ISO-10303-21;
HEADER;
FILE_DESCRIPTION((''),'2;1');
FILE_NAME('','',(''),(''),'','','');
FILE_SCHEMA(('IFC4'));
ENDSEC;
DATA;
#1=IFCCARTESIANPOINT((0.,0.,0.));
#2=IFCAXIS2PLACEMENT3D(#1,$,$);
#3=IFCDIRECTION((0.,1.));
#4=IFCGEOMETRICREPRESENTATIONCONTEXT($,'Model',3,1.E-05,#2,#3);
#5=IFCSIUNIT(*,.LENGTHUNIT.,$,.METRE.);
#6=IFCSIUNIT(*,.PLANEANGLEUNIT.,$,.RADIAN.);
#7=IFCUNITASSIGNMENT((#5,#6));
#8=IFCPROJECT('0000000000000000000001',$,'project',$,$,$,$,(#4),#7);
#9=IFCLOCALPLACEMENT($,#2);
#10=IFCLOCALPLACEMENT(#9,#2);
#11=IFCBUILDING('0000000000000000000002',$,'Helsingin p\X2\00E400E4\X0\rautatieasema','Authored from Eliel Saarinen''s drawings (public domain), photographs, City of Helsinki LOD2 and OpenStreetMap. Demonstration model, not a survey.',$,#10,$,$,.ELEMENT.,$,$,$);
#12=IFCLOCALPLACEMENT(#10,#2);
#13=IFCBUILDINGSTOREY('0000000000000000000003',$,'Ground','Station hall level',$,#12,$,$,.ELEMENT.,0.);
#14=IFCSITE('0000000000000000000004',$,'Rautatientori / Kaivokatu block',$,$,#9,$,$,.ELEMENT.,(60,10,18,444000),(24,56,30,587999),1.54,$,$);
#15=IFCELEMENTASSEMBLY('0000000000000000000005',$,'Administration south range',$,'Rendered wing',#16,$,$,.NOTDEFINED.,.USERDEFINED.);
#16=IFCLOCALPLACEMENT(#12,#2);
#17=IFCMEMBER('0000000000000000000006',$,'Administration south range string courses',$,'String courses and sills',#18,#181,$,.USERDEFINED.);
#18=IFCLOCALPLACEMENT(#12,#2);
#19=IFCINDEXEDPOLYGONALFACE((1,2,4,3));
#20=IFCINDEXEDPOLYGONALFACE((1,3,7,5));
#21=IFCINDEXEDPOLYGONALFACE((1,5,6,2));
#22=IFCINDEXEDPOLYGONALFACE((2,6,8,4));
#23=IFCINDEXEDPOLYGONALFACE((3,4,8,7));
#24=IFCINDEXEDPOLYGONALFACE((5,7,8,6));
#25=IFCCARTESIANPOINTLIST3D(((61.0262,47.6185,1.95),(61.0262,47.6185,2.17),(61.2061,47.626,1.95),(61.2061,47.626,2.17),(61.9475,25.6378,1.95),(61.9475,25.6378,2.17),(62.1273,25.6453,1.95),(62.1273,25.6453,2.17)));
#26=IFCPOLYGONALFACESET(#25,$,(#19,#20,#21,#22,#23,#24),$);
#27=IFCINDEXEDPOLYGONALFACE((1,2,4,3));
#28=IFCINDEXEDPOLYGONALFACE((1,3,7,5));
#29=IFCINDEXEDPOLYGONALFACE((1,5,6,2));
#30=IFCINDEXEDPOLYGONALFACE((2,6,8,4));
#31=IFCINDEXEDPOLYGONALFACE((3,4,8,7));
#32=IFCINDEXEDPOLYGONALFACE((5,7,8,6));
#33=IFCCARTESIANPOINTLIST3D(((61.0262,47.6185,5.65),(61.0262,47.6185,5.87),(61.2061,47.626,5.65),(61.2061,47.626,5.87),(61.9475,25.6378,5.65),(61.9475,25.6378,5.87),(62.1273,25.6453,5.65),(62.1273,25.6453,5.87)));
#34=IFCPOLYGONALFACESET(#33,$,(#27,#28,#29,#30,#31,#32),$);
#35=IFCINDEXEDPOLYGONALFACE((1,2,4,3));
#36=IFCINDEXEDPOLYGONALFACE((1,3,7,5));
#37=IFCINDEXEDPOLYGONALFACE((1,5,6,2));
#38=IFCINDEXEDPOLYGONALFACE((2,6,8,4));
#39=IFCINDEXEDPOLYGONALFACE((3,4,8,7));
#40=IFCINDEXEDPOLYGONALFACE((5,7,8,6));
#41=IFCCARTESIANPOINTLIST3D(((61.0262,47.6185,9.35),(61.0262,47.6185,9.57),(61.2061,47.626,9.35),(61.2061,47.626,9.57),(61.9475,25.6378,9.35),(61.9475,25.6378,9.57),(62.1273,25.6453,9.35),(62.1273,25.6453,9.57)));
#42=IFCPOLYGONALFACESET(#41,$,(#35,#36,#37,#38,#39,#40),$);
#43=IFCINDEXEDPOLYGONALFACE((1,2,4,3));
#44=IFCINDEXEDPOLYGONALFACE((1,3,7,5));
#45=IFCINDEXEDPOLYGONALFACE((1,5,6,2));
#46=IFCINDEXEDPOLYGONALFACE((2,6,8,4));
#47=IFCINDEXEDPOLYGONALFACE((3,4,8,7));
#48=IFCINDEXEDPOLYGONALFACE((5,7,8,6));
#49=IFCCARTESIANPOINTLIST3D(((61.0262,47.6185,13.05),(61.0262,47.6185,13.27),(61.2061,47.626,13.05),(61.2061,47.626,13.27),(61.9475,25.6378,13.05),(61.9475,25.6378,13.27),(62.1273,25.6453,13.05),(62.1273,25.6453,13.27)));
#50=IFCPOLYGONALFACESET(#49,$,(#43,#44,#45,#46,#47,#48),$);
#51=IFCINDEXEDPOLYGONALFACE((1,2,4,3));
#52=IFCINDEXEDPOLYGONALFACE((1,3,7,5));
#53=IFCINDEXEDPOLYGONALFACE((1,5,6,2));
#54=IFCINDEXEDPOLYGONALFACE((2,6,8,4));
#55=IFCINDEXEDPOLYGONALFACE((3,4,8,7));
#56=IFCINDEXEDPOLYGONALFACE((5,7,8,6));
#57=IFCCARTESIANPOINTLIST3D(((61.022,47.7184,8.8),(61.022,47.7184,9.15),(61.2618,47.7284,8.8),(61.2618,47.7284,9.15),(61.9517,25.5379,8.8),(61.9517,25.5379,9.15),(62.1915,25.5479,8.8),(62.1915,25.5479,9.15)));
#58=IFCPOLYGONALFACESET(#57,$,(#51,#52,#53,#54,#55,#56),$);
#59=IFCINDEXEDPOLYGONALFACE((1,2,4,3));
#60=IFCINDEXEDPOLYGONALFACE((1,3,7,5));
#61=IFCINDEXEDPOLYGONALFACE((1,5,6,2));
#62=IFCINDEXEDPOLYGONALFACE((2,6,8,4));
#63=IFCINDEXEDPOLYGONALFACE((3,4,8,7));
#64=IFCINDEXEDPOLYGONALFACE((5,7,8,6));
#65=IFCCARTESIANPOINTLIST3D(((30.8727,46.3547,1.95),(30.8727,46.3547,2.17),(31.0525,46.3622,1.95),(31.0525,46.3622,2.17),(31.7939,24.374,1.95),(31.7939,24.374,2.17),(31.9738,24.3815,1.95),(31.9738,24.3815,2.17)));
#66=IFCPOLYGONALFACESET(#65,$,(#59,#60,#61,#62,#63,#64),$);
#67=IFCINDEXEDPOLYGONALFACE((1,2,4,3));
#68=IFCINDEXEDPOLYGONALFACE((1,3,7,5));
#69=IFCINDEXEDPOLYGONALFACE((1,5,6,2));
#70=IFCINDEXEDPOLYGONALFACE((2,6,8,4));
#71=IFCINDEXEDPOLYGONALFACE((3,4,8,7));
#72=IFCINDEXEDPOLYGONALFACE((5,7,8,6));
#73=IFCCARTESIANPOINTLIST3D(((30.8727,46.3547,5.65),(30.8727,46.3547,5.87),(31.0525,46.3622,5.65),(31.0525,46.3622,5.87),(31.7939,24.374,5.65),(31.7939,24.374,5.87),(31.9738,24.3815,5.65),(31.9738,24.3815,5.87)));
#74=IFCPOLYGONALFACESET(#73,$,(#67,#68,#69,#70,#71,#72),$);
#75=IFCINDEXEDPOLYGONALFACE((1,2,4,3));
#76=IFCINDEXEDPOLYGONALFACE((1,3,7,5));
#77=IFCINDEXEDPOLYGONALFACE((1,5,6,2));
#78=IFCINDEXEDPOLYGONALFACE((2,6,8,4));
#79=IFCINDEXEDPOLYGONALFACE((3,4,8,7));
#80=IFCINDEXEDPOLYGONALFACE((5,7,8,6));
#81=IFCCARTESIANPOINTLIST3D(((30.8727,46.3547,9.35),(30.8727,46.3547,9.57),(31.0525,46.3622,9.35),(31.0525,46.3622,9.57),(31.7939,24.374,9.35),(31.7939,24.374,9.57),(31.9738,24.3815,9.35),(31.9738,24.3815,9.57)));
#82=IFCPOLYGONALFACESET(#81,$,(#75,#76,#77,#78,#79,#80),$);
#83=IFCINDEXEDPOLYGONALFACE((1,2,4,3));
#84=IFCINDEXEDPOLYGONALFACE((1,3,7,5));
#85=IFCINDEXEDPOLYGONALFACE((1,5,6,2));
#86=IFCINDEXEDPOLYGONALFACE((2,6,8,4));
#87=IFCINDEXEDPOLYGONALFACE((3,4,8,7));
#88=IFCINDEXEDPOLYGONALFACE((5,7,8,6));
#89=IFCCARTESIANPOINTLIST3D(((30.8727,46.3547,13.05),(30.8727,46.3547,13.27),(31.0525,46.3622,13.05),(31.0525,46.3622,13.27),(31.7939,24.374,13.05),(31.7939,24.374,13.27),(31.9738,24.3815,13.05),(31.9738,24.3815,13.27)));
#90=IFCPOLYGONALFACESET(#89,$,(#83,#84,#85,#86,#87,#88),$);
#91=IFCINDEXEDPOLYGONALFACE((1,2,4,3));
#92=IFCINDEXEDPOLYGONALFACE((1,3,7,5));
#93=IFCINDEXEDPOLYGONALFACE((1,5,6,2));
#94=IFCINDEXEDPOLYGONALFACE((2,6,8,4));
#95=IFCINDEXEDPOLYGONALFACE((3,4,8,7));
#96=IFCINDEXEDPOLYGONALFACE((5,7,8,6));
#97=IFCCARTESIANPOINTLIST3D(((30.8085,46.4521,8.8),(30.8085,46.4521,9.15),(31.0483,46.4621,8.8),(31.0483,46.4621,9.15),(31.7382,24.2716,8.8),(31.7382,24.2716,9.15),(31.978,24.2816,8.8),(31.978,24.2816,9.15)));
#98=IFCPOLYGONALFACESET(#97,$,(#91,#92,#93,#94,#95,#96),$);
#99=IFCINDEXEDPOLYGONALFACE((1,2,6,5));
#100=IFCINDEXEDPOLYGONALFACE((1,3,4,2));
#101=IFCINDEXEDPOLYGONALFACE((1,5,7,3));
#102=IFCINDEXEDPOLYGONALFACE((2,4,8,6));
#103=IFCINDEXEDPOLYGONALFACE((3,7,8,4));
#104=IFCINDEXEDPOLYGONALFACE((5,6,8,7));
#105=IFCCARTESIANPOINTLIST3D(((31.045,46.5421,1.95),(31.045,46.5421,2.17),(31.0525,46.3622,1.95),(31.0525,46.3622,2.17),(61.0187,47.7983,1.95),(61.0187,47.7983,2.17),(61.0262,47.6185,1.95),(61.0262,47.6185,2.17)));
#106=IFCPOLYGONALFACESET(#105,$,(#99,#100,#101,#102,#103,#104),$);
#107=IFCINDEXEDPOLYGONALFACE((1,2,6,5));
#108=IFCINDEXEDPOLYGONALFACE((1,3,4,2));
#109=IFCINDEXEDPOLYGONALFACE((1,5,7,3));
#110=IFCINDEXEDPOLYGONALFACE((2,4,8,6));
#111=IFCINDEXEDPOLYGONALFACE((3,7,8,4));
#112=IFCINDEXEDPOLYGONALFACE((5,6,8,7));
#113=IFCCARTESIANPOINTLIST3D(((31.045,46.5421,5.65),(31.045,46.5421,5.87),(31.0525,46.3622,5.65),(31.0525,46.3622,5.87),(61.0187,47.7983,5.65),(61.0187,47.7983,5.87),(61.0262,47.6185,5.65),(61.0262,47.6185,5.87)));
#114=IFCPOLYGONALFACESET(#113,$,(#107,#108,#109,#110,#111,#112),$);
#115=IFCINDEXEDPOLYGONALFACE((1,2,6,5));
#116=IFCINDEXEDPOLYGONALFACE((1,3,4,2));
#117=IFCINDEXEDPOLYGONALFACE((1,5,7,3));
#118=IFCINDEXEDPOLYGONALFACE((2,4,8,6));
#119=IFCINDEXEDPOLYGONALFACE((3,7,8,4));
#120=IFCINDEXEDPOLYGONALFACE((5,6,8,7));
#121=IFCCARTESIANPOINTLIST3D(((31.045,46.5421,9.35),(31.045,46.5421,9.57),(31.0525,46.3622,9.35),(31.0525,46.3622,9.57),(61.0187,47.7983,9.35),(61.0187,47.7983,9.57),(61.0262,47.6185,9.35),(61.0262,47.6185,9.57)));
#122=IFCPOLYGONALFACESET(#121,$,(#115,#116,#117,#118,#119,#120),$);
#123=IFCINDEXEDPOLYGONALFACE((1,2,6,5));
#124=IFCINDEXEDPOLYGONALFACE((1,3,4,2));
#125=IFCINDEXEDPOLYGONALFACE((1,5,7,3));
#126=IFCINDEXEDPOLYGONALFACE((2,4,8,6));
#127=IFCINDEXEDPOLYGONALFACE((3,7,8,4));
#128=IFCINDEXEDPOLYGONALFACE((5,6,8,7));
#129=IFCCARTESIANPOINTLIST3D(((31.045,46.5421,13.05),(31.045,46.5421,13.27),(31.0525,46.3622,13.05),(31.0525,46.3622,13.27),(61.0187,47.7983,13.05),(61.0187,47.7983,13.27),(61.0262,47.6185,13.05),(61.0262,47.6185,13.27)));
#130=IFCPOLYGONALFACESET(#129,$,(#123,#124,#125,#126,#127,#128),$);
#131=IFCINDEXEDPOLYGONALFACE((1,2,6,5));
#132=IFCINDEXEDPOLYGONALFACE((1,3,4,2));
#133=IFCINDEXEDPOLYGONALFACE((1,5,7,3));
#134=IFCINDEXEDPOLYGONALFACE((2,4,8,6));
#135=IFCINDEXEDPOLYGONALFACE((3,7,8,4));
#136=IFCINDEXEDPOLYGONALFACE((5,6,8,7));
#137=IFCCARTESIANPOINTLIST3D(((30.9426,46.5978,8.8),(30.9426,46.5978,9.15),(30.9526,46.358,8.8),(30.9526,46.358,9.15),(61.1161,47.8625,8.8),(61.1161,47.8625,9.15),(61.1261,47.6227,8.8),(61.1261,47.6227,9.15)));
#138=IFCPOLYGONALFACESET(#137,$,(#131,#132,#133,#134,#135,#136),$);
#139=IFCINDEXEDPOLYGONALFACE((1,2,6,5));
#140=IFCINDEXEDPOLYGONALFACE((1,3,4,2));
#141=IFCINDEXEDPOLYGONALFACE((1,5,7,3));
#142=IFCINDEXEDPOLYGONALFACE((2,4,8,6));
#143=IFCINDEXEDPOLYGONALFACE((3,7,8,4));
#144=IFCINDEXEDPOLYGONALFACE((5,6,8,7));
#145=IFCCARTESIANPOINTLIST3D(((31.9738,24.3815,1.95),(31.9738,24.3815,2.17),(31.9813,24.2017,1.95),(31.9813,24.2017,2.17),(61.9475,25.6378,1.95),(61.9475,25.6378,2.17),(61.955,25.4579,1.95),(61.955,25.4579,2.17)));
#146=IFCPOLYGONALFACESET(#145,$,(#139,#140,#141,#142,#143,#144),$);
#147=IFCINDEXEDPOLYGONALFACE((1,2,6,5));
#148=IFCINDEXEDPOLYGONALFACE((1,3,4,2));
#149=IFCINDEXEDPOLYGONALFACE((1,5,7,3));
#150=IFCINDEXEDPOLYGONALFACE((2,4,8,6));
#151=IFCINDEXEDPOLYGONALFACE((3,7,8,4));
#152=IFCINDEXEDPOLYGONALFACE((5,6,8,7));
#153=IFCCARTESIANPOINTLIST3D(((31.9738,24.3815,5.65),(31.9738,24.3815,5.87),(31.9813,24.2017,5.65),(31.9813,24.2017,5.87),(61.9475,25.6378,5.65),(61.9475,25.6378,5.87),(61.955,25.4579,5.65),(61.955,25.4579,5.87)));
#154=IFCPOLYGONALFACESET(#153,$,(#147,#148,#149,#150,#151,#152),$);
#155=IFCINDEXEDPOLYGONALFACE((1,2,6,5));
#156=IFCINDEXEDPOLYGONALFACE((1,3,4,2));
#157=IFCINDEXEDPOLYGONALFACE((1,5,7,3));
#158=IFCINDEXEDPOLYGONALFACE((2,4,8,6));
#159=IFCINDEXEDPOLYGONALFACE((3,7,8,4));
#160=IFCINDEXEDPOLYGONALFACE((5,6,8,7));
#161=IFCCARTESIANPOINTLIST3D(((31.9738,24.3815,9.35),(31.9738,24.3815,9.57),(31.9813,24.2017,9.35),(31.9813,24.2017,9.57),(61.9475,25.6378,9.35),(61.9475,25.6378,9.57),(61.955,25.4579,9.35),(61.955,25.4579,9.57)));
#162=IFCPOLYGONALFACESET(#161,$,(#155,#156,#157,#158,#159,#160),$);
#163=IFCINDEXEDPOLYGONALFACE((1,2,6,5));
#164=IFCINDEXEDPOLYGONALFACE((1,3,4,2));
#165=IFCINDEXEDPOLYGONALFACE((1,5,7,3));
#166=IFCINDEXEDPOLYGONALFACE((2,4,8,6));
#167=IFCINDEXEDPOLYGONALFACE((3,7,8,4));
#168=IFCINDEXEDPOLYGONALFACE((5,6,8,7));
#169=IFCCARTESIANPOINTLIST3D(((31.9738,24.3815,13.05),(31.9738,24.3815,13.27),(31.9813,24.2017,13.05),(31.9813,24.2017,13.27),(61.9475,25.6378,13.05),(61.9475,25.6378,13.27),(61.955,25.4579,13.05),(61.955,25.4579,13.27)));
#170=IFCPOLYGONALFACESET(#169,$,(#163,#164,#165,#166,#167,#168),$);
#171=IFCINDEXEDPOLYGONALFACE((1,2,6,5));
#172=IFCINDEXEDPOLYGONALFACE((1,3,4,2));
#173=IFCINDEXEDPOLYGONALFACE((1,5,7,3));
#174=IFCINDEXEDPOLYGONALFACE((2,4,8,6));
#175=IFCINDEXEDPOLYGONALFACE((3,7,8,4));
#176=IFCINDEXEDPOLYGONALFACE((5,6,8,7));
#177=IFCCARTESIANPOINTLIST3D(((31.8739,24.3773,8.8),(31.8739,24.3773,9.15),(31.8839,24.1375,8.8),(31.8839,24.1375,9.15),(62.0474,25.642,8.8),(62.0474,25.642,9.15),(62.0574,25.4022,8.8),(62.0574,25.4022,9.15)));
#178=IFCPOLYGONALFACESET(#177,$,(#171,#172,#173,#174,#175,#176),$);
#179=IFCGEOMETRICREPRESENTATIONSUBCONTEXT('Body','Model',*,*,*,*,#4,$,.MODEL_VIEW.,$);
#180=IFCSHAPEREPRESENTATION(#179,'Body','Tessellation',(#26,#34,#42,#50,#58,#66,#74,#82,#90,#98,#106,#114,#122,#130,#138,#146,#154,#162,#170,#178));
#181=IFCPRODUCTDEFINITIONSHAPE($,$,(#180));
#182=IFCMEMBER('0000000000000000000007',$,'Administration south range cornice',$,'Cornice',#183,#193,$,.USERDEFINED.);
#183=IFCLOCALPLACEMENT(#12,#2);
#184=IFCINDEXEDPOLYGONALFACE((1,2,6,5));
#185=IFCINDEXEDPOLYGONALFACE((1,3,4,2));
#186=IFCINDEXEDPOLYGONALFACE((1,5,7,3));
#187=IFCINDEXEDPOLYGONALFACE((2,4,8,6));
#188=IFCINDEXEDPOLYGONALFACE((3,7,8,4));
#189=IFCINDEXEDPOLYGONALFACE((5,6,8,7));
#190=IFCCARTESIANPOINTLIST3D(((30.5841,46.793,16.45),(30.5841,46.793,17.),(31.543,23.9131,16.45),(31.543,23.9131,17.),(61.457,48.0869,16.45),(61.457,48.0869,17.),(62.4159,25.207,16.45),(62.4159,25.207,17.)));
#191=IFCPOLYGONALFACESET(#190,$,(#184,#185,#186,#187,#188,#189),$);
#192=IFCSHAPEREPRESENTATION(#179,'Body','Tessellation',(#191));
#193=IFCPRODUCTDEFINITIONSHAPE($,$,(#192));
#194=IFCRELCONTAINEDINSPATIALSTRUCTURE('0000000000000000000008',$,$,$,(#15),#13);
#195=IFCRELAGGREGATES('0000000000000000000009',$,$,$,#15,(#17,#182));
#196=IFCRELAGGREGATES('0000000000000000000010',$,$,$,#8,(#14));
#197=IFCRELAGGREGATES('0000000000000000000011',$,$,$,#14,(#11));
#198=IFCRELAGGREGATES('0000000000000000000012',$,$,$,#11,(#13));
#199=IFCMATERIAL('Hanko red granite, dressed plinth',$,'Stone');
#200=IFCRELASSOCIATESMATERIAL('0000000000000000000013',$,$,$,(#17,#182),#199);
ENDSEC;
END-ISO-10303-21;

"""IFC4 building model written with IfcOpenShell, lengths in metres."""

from ifc_helpers import new_model, si_unit, direction, frame, frame_2d, origin, place, context, subcontext, project, spatial, rectangle, extrude, material, element, aggregate, save


model = new_model("IFC4")

# Units and contexts
model_context = context("Model", 3, precision=1e-05, world=origin(), true_north=direction((0.0, 1.0)))
body_context = subcontext(model_context, "Body", "Model", "MODEL_VIEW")
ifc_project = project(units=[si_unit("LENGTHUNIT", "METRE"), si_unit("PLANEANGLEUNIT", "RADIAN")], contexts=[model_context])

# Site, building, storey
site_placement = place(None, origin())
site = spatial("IfcSite", under=ifc_project, at=site_placement, Name="Rautatientori / Kaivokatu block", CompositionType="ELEMENT", RefLatitude=(60, 10, 18, 444000), RefLongitude=(24, 56, 30, 587999), RefElevation=1.54)
building_placement = place(site_placement, origin())
building = spatial("IfcBuilding", under=site, at=building_placement, Name="Helsingin päärautatieasema", Description="Authored from Eliel Saarinen's drawings (public domain), photographs, City of Helsinki LOD2 and OpenStreetMap. Demonstration model, not a survey.", CompositionType="ELEMENT")
storey_placement = place(building_placement, origin())
storey = spatial("IfcBuildingStorey", under=building, at=storey_placement, Name="Ground", Description="Station hall level", CompositionType="ELEMENT", Elevation=0.0)

# Element assembly, members
assembly_1_placement = place(building_placement, origin())
assembly_1 = element("IfcElementAssembly", 1, at=assembly_1_placement, inside=storey, Name="Administration south range", ObjectType="Rendered wing", AssemblyPlace="NOTDEFINED", PredefinedType="USERDEFINED")
ifc_material_1 = material(Name="Hanko red granite, dressed plinth", Category="Stone")
member_1_placement = place(building_placement, origin())
member_1 = element("IfcMember", 2, at=member_1_placement, material=ifc_material_1, Name="Administration south range string courses", ObjectType="String courses and sills", PredefinedType="USERDEFINED", context=body_context, shape_type="SweptSolid", body=[
    extrude(rectangle(XDim=22.0, YDim=0.18, at=frame_2d((0.0, 0.0), x_axis=(-0.041876, 0.999123))), frame((61.5768, 36.6319, 1.95)), (0.0, 0.0, 1.0), 0.22),
    extrude(rectangle(XDim=22.0, YDim=0.18, at=frame_2d((0.0, 0.0), x_axis=(-0.041876, 0.999123))), frame((61.5768, 36.6319, 5.65)), (0.0, 0.0, 1.0), 0.22),
    extrude(rectangle(XDim=22.0, YDim=0.18, at=frame_2d((0.0, 0.0), x_axis=(-0.041876, 0.999123))), frame((61.5768, 36.6319, 9.35)), (0.0, 0.0, 1.0), 0.22),
    extrude(rectangle(XDim=22.0, YDim=0.18, at=frame_2d((0.0, 0.0), x_axis=(-0.041876, 0.999123))), frame((61.5768, 36.6319, 13.05)), (0.0, 0.0, 1.0), 0.22),
    extrude(rectangle(XDim=22.2, YDim=0.24, at=frame_2d((0.0, 0.0), x_axis=(-0.041876, 0.999123))), frame((61.6067, 36.6332, 8.8)), (0.0, 0.0, 1.0), 0.35),
    extrude(rectangle(XDim=22.0, YDim=0.18, at=frame_2d((0.0, 0.0), x_axis=(0.041876, -0.999123))), frame((31.4232, 35.3681, 1.95)), (0.0, 0.0, 1.0), 0.22),
    extrude(rectangle(XDim=22.0, YDim=0.18, at=frame_2d((0.0, 0.0), x_axis=(0.041876, -0.999123))), frame((31.4232, 35.3681, 5.65)), (0.0, 0.0, 1.0), 0.22),
    extrude(rectangle(XDim=22.0, YDim=0.18, at=frame_2d((0.0, 0.0), x_axis=(0.041876, -0.999123))), frame((31.4232, 35.3681, 9.35)), (0.0, 0.0, 1.0), 0.22),
    extrude(rectangle(XDim=22.0, YDim=0.18, at=frame_2d((0.0, 0.0), x_axis=(0.041876, -0.999123))), frame((31.4232, 35.3681, 13.05)), (0.0, 0.0, 1.0), 0.22),
    extrude(rectangle(XDim=22.2, YDim=0.24, at=frame_2d((0.0, 0.0), x_axis=(0.041876, -0.999123))), frame((31.3933, 35.3668, 8.8)), (0.0, 0.0, 1.0), 0.35),
    extrude(rectangle(XDim=30.0, YDim=0.18, at=frame_2d((0.0, 0.0), x_axis=(-0.999123, -0.041876))), frame((46.0356, 47.0803, 1.95)), (0.0, 0.0, 1.0), 0.22),
    extrude(rectangle(XDim=30.0, YDim=0.18, at=frame_2d((0.0, 0.0), x_axis=(-0.999123, -0.041876))), frame((46.0356, 47.0803, 5.65)), (0.0, 0.0, 1.0), 0.22),
    extrude(rectangle(XDim=30.0, YDim=0.18, at=frame_2d((0.0, 0.0), x_axis=(-0.999123, -0.041876))), frame((46.0356, 47.0803, 9.35)), (0.0, 0.0, 1.0), 0.22),
    extrude(rectangle(XDim=30.0, YDim=0.18, at=frame_2d((0.0, 0.0), x_axis=(-0.999123, -0.041876))), frame((46.0356, 47.0803, 13.05)), (0.0, 0.0, 1.0), 0.22),
    extrude(rectangle(XDim=30.2, YDim=0.24, at=frame_2d((0.0, 0.0), x_axis=(-0.999123, -0.041876))), frame((46.0343, 47.1102, 8.8)), (0.0, 0.0, 1.0), 0.35),
    extrude(rectangle(XDim=30.0, YDim=0.18, at=frame_2d((0.0, 0.0), x_axis=(0.999123, 0.041876))), frame((46.9644, 24.9197, 1.95)), (0.0, 0.0, 1.0), 0.22),
    extrude(rectangle(XDim=30.0, YDim=0.18, at=frame_2d((0.0, 0.0), x_axis=(0.999123, 0.041876))), frame((46.9644, 24.9197, 5.65)), (0.0, 0.0, 1.0), 0.22),
    extrude(rectangle(XDim=30.0, YDim=0.18, at=frame_2d((0.0, 0.0), x_axis=(0.999123, 0.041876))), frame((46.9644, 24.9197, 9.35)), (0.0, 0.0, 1.0), 0.22),
    extrude(rectangle(XDim=30.0, YDim=0.18, at=frame_2d((0.0, 0.0), x_axis=(0.999123, 0.041876))), frame((46.9644, 24.9197, 13.05)), (0.0, 0.0, 1.0), 0.22),
    extrude(rectangle(XDim=30.2, YDim=0.24, at=frame_2d((0.0, 0.0), x_axis=(0.999123, 0.041876))), frame((46.9657, 24.8898, 8.8)), (0.0, 0.0, 1.0), 0.35),
])
member_2_placement = place(building_placement, origin())
member_2 = element("IfcMember", 3, at=member_2_placement, material=ifc_material_1, Name="Administration south range cornice", ObjectType="Cornice", PredefinedType="USERDEFINED", context=body_context, shape_type="SweptSolid", body=[
    extrude(rectangle(XDim=30.9, YDim=22.9, at=frame_2d((0.0, 0.0), x_axis=(0.999123, 0.041876))), frame((46.5, 36.0, 16.45)), (0.0, 0.0, 1.0), 0.55),
])

aggregate(assembly_1, [member_1, member_2])

save(model, "model.ifc")
